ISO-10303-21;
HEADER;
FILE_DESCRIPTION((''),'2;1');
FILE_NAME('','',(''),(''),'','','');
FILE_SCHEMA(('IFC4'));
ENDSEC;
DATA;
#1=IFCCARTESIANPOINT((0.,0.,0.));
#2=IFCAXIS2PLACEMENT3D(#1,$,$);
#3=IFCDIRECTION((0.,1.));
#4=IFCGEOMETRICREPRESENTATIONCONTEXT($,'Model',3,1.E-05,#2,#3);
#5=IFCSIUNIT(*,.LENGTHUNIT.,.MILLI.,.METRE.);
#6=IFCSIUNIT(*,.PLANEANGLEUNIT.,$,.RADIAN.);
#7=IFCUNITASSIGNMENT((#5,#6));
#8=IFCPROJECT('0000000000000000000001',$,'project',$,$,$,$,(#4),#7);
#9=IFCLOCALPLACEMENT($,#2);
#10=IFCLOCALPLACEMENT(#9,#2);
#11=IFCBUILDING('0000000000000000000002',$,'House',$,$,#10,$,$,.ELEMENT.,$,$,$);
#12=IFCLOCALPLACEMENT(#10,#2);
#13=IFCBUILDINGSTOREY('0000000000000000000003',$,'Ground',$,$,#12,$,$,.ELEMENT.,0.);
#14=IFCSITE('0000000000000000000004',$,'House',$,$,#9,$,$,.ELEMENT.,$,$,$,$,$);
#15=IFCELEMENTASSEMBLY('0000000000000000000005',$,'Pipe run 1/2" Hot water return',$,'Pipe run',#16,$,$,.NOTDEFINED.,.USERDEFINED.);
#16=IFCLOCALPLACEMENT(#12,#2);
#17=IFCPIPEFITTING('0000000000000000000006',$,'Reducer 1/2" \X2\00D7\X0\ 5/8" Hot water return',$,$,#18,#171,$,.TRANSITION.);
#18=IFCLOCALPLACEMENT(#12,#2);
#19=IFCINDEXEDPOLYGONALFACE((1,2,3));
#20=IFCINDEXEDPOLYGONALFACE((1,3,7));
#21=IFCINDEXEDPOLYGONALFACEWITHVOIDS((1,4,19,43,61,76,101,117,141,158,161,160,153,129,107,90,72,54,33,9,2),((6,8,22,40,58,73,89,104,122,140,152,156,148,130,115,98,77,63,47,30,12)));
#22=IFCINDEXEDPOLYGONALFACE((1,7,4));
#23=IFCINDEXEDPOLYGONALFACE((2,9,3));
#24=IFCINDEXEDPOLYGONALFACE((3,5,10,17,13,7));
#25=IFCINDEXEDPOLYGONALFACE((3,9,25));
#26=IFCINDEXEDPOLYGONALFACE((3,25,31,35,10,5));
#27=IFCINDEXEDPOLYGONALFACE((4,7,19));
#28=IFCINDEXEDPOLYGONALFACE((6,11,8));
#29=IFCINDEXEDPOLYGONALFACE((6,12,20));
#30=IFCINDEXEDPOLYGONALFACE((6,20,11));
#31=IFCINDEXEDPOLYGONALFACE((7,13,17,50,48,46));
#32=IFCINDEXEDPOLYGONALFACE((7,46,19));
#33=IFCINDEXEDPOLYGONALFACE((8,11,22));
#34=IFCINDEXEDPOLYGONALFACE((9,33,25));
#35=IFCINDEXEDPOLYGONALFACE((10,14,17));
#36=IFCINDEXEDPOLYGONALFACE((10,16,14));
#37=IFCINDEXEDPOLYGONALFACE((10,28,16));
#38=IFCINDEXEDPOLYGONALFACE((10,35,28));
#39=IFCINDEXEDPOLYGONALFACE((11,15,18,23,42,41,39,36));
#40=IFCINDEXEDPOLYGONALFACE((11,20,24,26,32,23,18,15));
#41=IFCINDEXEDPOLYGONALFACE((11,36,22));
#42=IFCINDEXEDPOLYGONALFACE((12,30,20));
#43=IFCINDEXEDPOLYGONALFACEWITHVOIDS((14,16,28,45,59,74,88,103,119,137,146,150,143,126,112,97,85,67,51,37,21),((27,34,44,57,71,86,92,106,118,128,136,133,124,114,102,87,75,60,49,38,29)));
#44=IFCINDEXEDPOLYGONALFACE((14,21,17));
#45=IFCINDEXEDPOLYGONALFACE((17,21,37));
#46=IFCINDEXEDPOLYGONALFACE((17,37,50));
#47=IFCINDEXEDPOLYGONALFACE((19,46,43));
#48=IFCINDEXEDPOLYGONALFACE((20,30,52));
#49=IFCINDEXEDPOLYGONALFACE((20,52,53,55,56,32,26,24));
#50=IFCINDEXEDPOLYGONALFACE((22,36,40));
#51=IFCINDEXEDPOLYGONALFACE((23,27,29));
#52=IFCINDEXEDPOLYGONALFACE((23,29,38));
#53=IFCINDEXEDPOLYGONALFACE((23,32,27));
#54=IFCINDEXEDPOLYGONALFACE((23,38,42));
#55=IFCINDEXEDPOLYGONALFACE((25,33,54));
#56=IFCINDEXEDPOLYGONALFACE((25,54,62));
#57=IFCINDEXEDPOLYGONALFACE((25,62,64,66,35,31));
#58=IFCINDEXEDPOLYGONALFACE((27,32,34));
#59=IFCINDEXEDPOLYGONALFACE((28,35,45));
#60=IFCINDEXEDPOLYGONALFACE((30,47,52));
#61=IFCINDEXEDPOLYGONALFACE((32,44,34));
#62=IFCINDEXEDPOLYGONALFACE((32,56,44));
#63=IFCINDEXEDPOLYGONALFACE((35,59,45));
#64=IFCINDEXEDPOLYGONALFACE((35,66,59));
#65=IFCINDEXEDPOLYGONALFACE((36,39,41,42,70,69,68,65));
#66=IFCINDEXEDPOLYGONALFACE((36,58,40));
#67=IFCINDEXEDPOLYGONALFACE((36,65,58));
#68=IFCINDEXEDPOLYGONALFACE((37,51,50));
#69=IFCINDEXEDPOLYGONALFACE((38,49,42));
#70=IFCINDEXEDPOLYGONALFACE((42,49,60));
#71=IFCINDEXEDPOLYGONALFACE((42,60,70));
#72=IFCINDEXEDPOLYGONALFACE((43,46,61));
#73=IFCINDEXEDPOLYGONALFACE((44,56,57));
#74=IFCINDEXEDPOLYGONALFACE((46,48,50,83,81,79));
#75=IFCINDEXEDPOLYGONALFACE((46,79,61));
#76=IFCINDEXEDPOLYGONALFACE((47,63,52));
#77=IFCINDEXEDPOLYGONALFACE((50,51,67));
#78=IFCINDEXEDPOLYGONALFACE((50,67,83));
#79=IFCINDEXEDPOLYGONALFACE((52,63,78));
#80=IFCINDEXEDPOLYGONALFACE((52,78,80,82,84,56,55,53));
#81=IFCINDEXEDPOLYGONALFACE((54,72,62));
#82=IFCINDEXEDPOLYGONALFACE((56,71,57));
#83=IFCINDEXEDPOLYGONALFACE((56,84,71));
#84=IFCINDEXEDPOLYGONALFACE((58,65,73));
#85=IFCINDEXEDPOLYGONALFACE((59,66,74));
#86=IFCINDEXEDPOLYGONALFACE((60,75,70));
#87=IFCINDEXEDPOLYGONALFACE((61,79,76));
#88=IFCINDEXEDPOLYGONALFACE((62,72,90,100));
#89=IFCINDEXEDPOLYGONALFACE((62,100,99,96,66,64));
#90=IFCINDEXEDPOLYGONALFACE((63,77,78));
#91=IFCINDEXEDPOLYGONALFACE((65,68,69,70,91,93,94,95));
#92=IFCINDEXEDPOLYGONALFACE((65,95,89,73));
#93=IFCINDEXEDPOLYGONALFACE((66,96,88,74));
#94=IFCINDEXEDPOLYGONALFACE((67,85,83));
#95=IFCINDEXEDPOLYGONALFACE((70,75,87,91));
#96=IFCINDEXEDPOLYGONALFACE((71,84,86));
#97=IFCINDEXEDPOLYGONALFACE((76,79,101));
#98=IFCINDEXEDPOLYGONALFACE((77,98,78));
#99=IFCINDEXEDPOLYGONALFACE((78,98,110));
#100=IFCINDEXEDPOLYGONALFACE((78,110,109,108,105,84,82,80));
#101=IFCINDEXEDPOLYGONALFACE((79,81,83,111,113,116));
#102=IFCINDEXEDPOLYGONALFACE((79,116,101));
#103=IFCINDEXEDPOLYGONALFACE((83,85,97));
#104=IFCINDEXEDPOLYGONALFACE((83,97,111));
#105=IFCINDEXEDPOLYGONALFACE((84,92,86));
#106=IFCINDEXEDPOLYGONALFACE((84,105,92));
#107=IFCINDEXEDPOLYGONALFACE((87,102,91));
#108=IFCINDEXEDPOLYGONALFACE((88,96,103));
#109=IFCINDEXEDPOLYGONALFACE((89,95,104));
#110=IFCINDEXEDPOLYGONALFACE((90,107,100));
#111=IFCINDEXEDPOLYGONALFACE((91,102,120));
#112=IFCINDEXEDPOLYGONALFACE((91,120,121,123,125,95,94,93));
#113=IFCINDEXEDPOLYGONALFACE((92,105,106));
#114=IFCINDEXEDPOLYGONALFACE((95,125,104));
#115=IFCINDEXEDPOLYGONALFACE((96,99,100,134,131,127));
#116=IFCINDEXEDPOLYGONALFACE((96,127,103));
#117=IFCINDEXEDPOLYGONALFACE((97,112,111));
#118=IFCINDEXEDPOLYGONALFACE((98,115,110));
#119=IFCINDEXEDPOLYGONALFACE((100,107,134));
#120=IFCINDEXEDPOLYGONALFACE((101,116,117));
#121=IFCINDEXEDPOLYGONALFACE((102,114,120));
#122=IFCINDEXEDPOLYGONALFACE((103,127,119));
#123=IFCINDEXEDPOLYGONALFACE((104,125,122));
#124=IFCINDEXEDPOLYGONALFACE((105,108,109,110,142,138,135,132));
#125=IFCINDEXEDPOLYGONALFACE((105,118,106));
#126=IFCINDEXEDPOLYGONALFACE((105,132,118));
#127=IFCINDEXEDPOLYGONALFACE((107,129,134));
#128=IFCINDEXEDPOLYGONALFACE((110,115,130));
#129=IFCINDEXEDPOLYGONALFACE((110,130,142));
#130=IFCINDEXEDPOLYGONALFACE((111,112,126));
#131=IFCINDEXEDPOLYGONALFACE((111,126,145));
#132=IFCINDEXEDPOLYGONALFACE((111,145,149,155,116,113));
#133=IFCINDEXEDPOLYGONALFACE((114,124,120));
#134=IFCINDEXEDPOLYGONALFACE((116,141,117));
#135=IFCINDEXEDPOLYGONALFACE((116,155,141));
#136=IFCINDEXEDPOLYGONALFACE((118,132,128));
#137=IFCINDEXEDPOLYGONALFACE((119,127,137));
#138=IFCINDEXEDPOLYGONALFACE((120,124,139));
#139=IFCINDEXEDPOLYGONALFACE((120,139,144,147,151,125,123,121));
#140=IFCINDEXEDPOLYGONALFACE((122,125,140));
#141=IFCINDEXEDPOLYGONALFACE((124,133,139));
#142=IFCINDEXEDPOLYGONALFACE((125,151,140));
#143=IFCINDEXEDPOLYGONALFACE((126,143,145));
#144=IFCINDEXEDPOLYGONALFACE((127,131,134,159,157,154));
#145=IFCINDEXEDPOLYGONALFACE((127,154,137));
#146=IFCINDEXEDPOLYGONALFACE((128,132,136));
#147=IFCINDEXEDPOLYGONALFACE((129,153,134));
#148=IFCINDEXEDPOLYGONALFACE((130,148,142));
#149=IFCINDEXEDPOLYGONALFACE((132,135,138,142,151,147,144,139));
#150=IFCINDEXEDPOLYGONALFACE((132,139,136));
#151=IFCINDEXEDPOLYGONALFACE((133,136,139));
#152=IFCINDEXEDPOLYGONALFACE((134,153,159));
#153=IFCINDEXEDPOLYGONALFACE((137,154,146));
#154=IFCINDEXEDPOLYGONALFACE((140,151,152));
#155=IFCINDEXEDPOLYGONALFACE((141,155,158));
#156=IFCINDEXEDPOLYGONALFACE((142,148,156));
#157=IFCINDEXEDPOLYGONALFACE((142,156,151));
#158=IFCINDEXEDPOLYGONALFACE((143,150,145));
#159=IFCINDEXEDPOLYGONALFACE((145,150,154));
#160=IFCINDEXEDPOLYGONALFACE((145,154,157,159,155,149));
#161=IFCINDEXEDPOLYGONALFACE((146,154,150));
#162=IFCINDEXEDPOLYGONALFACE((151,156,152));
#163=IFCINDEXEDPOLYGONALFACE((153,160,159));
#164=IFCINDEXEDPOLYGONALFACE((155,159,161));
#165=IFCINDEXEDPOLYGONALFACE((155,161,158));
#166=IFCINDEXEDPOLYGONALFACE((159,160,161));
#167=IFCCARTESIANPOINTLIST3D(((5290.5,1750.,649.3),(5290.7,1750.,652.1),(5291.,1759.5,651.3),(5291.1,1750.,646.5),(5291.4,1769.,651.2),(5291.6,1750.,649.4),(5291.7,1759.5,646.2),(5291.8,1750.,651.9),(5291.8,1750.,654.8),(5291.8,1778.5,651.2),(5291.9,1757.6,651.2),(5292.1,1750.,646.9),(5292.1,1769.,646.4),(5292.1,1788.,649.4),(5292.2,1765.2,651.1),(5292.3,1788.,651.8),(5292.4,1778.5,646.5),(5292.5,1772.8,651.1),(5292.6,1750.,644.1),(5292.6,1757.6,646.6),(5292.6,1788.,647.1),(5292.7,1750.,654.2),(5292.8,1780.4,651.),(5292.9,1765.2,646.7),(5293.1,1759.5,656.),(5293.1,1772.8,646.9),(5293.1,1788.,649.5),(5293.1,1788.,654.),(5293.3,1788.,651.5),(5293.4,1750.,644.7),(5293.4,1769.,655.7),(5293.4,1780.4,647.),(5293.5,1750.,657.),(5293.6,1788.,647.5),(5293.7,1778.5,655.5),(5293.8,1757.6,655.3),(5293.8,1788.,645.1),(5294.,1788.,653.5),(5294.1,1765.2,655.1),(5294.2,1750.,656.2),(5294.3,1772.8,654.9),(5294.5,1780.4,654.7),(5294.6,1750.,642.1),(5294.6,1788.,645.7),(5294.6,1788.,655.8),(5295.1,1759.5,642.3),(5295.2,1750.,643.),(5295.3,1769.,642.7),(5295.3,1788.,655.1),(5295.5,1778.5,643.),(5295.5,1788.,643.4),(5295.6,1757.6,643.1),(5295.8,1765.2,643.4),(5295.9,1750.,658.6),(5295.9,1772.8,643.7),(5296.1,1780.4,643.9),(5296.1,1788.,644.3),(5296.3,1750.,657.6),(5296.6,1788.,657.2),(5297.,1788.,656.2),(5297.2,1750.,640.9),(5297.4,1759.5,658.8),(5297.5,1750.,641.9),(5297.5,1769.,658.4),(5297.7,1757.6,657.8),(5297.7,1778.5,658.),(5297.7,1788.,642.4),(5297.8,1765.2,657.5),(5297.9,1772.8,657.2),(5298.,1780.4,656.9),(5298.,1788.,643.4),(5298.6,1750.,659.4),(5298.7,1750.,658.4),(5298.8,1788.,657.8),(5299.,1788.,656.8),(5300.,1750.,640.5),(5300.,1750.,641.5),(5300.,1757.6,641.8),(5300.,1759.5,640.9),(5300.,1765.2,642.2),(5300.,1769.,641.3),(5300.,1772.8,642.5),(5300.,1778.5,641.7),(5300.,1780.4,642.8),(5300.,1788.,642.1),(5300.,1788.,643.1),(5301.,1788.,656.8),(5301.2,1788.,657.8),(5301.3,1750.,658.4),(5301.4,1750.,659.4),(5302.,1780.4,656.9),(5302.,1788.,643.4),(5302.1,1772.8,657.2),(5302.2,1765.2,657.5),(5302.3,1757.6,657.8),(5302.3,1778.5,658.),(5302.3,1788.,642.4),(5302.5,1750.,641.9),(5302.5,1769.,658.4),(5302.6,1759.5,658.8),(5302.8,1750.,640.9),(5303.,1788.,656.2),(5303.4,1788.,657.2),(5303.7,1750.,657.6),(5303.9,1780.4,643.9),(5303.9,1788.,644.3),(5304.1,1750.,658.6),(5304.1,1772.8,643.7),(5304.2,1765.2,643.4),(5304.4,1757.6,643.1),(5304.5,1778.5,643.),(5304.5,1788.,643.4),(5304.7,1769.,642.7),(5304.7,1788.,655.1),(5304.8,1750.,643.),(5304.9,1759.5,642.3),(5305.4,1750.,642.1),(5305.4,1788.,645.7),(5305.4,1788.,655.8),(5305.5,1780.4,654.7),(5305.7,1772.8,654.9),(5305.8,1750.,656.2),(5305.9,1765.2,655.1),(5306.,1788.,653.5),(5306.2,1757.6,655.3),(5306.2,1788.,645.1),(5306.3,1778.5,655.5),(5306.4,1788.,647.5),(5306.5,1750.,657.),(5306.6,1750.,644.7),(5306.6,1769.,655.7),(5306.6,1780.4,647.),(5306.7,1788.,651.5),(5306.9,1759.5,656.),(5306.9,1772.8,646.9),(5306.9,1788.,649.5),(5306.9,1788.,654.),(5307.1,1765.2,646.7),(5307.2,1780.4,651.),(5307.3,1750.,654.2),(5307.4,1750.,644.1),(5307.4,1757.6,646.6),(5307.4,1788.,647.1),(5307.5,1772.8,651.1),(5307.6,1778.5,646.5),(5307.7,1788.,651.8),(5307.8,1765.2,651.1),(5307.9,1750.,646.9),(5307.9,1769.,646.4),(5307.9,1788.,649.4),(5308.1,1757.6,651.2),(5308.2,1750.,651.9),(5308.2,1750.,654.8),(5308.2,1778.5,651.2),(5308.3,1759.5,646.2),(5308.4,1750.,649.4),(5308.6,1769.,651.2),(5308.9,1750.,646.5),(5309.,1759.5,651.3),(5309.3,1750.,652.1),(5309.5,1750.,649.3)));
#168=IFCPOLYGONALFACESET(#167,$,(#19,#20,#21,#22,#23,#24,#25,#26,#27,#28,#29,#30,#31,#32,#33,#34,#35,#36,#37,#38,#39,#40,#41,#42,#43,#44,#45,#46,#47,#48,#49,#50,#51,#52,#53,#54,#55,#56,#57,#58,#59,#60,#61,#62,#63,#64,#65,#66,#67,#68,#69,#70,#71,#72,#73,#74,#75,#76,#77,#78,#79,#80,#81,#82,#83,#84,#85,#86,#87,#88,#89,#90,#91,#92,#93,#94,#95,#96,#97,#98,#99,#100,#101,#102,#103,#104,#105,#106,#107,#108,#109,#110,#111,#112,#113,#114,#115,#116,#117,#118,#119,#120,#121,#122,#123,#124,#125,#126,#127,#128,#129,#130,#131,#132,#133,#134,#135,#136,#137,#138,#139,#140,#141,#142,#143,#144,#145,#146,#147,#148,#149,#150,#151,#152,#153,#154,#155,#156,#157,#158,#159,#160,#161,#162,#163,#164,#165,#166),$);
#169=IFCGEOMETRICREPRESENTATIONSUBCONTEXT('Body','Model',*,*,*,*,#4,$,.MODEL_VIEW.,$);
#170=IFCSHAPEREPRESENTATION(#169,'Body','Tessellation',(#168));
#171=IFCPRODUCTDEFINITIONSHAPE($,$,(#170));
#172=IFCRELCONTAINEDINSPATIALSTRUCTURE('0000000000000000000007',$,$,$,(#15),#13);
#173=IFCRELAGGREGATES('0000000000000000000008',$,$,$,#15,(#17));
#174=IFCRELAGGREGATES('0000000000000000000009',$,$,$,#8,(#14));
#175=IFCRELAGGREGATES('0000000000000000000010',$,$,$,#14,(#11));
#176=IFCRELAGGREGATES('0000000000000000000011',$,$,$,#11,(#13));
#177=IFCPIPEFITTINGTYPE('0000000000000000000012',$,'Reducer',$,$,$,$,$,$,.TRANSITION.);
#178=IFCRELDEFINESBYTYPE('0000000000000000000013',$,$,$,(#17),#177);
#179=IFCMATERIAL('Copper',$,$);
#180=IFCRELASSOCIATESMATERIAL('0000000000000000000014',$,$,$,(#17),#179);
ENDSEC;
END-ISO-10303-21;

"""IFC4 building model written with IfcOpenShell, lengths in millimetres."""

from ifc_helpers import new_model, entity, si_unit, direction, origin, origin_with_axes, place, context, subcontext, project, spatial, material, type_object, element, aggregate, save


model = new_model("IFC4")

# Units and contexts
model_context = context("Model", 3, precision=1e-05, world=origin(), true_north=direction((0.0, 1.0)))
body_context = subcontext(model_context, "Body", "Model", "MODEL_VIEW")
ifc_project = project(units=[si_unit("LENGTHUNIT", "METRE", prefix="MILLI"), si_unit("PLANEANGLEUNIT", "RADIAN")], contexts=[model_context])

# Site, building, storey
site_placement = place(None, origin())
site = spatial("IfcSite", under=ifc_project, at=site_placement, Name="House", CompositionType="ELEMENT")
building_placement = place(site_placement, origin())
building = spatial("IfcBuilding", under=site, at=building_placement, Name="House", CompositionType="ELEMENT")
storey_placement = place(building_placement, origin())
storey = spatial("IfcBuildingStorey", under=building, at=storey_placement, Name="Ground", CompositionType="ELEMENT", Elevation=0.0)

# Element assembly
ifc_material = material(Name="Copper")
assembly_1_placement = place(storey_placement, origin_with_axes())
assembly_1 = element("IfcElementAssembly", 1, at=assembly_1_placement, inside=storey, Name="Pipe run 1/2\" Hot water return", ObjectType="Pipe run", AssemblyPlace="NOTDEFINED", PredefinedType="USERDEFINED")

# Shared definitions
pipe_fitting_type_1 = type_object("IfcPipeFittingType", Name="Reducer", PredefinedType="TRANSITION")

# Pipe fitting
pipe_fitting_1_placement = place(storey_placement, origin_with_axes())
cartesian_point_1 = entity("IfcCartesianPoint", [0.0, 6.9])
pipe_fitting_1 = element("IfcPipeFitting", 2, at=pipe_fitting_1_placement, type_object=pipe_fitting_type_1, material=ifc_material, Name="Reducer 1/2\" × 5/8\" Hot water return", PredefinedType="TRANSITION", context=body_context, shape_type="SweptSolid", body=[
    entity("IfcRevolvedAreaSolid", entity("IfcArbitraryClosedProfileDef", "AREA", None, entity("IfcPolyline", [cartesian_point_1, entity("IfcCartesianPoint", [0.0, 7.9]), entity("IfcCartesianPoint", [38.0, 9.5]), entity("IfcCartesianPoint", [38.0, 8.5]), cartesian_point_1])), entity("IfcAxis2Placement3D", entity("IfcCartesianPoint", [5300.0, 1788.0, 650.0]), entity("IfcDirection", [1.0, 0.0, 0.0]), entity("IfcDirection", [0.0, -1.0, 0.0])), entity("IfcAxis1Placement", entity("IfcCartesianPoint", [0.0, 0.0, 0.0]), entity("IfcDirection", [1.0, 0.0, 0.0])), 6.283185),
])
aggregate(assembly_1, [pipe_fitting_1])

save(model, "model.ifc")
